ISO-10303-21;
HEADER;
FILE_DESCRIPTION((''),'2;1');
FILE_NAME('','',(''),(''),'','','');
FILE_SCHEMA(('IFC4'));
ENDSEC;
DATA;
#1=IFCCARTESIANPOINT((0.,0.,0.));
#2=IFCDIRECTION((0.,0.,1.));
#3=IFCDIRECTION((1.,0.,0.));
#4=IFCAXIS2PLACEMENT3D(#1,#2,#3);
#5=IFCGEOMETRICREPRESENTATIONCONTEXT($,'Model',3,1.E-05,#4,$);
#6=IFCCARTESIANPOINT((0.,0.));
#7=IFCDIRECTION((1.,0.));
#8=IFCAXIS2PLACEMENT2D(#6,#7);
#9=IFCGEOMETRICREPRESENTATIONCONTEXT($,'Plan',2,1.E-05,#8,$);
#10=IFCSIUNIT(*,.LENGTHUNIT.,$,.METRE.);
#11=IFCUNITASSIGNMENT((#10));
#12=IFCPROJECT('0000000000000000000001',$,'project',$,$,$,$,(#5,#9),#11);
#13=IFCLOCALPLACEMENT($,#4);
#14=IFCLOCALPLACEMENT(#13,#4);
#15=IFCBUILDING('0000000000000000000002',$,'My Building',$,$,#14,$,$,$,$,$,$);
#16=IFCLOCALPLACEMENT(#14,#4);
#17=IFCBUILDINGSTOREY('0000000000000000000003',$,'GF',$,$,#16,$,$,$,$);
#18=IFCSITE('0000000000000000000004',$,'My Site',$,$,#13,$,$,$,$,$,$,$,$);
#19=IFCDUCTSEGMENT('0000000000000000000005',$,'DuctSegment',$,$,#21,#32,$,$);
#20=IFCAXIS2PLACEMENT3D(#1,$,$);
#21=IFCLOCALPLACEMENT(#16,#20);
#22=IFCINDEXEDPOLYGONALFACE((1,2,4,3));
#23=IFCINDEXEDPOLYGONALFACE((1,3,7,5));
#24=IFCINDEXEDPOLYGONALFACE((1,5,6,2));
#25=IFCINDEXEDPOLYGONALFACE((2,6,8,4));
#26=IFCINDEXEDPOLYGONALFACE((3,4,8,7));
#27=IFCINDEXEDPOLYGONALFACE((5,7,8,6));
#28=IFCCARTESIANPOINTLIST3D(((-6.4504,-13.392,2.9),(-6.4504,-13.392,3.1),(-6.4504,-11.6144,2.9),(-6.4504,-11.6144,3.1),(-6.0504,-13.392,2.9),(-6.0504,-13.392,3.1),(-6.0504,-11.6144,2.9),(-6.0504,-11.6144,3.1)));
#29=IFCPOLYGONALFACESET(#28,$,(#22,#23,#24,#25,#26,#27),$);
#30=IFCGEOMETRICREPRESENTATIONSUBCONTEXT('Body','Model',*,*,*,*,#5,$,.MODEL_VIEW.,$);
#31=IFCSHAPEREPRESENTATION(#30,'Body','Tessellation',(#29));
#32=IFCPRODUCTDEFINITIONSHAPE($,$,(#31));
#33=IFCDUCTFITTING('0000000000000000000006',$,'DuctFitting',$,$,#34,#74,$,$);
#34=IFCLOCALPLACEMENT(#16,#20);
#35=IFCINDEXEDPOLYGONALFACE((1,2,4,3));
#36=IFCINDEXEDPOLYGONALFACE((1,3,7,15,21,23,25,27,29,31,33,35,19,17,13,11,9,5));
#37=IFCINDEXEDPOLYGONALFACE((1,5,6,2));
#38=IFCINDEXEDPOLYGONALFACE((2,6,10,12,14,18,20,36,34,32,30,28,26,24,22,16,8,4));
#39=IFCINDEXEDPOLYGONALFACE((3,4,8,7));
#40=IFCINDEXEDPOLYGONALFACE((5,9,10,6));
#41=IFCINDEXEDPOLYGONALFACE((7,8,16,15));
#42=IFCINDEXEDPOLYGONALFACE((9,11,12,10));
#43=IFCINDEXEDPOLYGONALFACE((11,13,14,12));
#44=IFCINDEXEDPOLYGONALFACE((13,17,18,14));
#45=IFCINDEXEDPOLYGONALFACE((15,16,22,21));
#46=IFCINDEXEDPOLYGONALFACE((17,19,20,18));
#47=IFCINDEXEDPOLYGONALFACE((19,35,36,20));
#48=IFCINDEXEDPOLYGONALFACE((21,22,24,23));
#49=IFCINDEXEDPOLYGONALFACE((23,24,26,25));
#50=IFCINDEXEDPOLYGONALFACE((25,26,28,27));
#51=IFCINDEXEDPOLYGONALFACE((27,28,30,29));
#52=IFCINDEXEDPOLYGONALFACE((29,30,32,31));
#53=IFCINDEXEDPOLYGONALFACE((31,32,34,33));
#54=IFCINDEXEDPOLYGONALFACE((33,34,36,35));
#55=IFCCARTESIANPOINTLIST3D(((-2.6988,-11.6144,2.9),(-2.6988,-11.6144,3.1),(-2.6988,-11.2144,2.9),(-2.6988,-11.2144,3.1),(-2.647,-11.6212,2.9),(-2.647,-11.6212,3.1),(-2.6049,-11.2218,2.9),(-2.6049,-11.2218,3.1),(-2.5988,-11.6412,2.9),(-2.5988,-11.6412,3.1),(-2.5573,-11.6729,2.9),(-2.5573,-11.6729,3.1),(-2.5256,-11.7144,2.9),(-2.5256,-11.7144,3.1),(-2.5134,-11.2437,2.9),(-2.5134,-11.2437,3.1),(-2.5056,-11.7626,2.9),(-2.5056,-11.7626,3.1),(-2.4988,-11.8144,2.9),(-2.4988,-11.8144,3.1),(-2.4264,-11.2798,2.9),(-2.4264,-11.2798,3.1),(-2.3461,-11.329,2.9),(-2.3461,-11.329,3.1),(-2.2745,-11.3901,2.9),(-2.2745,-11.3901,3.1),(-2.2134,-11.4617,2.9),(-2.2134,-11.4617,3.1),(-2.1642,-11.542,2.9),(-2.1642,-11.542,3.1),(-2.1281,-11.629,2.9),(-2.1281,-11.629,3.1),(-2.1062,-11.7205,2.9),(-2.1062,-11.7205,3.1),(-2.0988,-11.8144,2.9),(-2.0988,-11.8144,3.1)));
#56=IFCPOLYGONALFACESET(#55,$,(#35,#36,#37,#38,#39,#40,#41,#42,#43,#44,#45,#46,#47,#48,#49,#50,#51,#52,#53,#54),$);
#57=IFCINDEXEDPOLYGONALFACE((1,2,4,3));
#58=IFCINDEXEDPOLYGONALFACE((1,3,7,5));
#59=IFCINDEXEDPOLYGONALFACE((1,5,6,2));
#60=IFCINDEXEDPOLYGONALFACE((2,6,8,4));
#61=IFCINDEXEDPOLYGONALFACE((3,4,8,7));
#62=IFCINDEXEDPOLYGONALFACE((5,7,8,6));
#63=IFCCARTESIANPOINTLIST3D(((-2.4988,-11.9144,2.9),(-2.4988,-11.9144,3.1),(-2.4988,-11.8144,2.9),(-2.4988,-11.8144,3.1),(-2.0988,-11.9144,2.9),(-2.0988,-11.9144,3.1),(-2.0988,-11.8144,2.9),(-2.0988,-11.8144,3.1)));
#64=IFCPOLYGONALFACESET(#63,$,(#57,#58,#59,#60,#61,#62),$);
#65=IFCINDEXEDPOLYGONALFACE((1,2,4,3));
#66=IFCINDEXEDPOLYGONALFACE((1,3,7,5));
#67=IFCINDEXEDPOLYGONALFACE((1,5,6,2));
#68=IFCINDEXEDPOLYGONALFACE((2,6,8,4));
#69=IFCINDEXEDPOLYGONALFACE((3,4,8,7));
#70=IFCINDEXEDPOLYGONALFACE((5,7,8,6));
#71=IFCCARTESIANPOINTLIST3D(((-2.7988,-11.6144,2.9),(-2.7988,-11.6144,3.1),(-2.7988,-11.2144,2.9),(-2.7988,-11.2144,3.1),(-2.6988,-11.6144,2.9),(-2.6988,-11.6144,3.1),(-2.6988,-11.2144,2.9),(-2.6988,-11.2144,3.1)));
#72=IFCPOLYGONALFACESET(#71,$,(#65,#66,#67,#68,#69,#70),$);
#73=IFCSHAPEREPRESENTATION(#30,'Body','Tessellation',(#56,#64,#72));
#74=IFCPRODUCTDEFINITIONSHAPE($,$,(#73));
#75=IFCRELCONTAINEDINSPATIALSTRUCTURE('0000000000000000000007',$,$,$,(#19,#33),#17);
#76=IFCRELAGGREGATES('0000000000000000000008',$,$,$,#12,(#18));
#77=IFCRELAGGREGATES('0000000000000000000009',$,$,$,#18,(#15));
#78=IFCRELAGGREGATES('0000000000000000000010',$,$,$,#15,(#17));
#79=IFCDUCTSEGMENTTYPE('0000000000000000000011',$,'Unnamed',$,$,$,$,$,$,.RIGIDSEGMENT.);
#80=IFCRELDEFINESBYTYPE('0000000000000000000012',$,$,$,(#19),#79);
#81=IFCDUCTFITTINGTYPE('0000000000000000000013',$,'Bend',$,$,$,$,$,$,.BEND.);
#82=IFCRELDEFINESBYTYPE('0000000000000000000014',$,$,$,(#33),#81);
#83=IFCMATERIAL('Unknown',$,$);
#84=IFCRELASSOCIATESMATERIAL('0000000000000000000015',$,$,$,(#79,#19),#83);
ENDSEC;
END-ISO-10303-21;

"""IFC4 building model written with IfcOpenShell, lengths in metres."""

from ifc_helpers import new_model, si_unit, frame, origin_with_axes, origin_2d_with_axis, place, context, subcontext, project, spatial, line, arc, indexed_curve, rectangle, outline, extrude, source, transform, mapped, material, material_profile, profile_set, profile_usage, type_object, type_shapes, element, save


model = new_model("IFC4")

# Units and contexts
model_context = context("Model", 3, precision=1e-05, world=origin_with_axes())
plan_context = context("Plan", 2, precision=1e-05, world=origin_2d_with_axis())
body_context_1 = subcontext(model_context, "Body", "Model", "MODEL_VIEW")
ifc_project = project(units=[si_unit("LENGTHUNIT", "METRE")], contexts=[model_context, plan_context])

# Site, building, storey
site_placement = place(None, origin_with_axes())
site = spatial("IfcSite", under=ifc_project, at=site_placement, Name="My Site")
building_placement = place(site_placement, origin_with_axes())
building = spatial("IfcBuilding", under=site, at=building_placement, Name="My Building")
storey_placement = place(building_placement, origin_with_axes())
storey = spatial("IfcBuildingStorey", under=building, at=storey_placement, Name="GF")

# Shared definitions
ifc_material = material(Name="Unknown")

# Duct segment
ifc_material_profile_1 = material_profile(ifc_material, rectangle(XDim=0.4, YDim=0.2))
ifc_profile_set_1 = profile_set([ifc_material_profile_1])
duct_segment_type = type_object("IfcDuctSegmentType", Name="Unnamed", PredefinedType="RIGIDSEGMENT", material=ifc_profile_set_1)
ifc_profile_usage_1 = profile_usage(ifc_profile_set_1, cardinal=5)
duct_segment_1_placement = place(storey_placement, frame((-6.2504, -11.6144, 3.0), z_axis=(0.0, -1.0, 0.0), x_axis=(1.0, 0.0, 0.0)))
element("IfcDuctSegment", 1, at=duct_segment_1_placement, inside=storey, type_object=duct_segment_type, material=ifc_profile_usage_1, Name="DuctSegment", context=body_context_1, shape_type="SweptSolid", body=[
    extrude(rectangle(XDim=0.4, YDim=0.2), origin_with_axes(), (0.0, 0.0, 1.0), 1.7777),
])

# Duct fitting
duct_fitting_type = type_object("IfcDuctFittingType", Name="Bend", PredefinedType="BEND")
shared_shape_1 = source(origin_with_axes(), body_context_1, "Body", "SweptSolid", [
    extrude(outline(indexed_curve([(-0.2, 0.0), (-0.2586, 0.1414), (-0.4, 0.2), (-0.4, 0.6), (0.0243, 0.4243), (0.2, 0.0)], segments=[arc(1, 2, 3), line(3, 4), arc(4, 5, 6), line(6, 1)])), frame((0.0, -0.1, 0.1), z_axis=(0.0, -1.0, 0.0), x_axis=(1.0, 0.0, 0.0)), (0.0, 0.0, -1.0), 0.2),
    extrude(rectangle(XDim=0.4, YDim=0.2), origin_with_axes(), (0.0, 0.0, 1.0), 0.1),
    extrude(rectangle(XDim=0.4, YDim=0.2), frame((-0.4, 0.0, 0.5), z_axis=(-1.0, 0.0, 0.0), x_axis=(0.0, 0.0, -1.0)), (0.0, 0.0, 1.0), 0.1),
])
type_shapes(duct_fitting_type, [shared_shape_1])
duct_fitting_placement = place(storey_placement, frame((-2.2988, -11.9144, 3.0), z_axis=(0.0, 1.0, 0.0), x_axis=(1.0, 0.0, 0.0)))
element("IfcDuctFitting", 2, at=duct_fitting_placement, inside=storey, type_object=duct_fitting_type, Name="DuctFitting", context=body_context_1, shape_type="MappedRepresentation", body=[
    mapped(shared_shape_1, transform((0.0, 0.0, 0.0), x_axis=(1.0, 0.0, 0.0), y_axis=(0.0, 1.0, 0.0), z_axis=(0.0, 0.0, 1.0), scale=1.0)),
])

save(model, "model.ifc")
